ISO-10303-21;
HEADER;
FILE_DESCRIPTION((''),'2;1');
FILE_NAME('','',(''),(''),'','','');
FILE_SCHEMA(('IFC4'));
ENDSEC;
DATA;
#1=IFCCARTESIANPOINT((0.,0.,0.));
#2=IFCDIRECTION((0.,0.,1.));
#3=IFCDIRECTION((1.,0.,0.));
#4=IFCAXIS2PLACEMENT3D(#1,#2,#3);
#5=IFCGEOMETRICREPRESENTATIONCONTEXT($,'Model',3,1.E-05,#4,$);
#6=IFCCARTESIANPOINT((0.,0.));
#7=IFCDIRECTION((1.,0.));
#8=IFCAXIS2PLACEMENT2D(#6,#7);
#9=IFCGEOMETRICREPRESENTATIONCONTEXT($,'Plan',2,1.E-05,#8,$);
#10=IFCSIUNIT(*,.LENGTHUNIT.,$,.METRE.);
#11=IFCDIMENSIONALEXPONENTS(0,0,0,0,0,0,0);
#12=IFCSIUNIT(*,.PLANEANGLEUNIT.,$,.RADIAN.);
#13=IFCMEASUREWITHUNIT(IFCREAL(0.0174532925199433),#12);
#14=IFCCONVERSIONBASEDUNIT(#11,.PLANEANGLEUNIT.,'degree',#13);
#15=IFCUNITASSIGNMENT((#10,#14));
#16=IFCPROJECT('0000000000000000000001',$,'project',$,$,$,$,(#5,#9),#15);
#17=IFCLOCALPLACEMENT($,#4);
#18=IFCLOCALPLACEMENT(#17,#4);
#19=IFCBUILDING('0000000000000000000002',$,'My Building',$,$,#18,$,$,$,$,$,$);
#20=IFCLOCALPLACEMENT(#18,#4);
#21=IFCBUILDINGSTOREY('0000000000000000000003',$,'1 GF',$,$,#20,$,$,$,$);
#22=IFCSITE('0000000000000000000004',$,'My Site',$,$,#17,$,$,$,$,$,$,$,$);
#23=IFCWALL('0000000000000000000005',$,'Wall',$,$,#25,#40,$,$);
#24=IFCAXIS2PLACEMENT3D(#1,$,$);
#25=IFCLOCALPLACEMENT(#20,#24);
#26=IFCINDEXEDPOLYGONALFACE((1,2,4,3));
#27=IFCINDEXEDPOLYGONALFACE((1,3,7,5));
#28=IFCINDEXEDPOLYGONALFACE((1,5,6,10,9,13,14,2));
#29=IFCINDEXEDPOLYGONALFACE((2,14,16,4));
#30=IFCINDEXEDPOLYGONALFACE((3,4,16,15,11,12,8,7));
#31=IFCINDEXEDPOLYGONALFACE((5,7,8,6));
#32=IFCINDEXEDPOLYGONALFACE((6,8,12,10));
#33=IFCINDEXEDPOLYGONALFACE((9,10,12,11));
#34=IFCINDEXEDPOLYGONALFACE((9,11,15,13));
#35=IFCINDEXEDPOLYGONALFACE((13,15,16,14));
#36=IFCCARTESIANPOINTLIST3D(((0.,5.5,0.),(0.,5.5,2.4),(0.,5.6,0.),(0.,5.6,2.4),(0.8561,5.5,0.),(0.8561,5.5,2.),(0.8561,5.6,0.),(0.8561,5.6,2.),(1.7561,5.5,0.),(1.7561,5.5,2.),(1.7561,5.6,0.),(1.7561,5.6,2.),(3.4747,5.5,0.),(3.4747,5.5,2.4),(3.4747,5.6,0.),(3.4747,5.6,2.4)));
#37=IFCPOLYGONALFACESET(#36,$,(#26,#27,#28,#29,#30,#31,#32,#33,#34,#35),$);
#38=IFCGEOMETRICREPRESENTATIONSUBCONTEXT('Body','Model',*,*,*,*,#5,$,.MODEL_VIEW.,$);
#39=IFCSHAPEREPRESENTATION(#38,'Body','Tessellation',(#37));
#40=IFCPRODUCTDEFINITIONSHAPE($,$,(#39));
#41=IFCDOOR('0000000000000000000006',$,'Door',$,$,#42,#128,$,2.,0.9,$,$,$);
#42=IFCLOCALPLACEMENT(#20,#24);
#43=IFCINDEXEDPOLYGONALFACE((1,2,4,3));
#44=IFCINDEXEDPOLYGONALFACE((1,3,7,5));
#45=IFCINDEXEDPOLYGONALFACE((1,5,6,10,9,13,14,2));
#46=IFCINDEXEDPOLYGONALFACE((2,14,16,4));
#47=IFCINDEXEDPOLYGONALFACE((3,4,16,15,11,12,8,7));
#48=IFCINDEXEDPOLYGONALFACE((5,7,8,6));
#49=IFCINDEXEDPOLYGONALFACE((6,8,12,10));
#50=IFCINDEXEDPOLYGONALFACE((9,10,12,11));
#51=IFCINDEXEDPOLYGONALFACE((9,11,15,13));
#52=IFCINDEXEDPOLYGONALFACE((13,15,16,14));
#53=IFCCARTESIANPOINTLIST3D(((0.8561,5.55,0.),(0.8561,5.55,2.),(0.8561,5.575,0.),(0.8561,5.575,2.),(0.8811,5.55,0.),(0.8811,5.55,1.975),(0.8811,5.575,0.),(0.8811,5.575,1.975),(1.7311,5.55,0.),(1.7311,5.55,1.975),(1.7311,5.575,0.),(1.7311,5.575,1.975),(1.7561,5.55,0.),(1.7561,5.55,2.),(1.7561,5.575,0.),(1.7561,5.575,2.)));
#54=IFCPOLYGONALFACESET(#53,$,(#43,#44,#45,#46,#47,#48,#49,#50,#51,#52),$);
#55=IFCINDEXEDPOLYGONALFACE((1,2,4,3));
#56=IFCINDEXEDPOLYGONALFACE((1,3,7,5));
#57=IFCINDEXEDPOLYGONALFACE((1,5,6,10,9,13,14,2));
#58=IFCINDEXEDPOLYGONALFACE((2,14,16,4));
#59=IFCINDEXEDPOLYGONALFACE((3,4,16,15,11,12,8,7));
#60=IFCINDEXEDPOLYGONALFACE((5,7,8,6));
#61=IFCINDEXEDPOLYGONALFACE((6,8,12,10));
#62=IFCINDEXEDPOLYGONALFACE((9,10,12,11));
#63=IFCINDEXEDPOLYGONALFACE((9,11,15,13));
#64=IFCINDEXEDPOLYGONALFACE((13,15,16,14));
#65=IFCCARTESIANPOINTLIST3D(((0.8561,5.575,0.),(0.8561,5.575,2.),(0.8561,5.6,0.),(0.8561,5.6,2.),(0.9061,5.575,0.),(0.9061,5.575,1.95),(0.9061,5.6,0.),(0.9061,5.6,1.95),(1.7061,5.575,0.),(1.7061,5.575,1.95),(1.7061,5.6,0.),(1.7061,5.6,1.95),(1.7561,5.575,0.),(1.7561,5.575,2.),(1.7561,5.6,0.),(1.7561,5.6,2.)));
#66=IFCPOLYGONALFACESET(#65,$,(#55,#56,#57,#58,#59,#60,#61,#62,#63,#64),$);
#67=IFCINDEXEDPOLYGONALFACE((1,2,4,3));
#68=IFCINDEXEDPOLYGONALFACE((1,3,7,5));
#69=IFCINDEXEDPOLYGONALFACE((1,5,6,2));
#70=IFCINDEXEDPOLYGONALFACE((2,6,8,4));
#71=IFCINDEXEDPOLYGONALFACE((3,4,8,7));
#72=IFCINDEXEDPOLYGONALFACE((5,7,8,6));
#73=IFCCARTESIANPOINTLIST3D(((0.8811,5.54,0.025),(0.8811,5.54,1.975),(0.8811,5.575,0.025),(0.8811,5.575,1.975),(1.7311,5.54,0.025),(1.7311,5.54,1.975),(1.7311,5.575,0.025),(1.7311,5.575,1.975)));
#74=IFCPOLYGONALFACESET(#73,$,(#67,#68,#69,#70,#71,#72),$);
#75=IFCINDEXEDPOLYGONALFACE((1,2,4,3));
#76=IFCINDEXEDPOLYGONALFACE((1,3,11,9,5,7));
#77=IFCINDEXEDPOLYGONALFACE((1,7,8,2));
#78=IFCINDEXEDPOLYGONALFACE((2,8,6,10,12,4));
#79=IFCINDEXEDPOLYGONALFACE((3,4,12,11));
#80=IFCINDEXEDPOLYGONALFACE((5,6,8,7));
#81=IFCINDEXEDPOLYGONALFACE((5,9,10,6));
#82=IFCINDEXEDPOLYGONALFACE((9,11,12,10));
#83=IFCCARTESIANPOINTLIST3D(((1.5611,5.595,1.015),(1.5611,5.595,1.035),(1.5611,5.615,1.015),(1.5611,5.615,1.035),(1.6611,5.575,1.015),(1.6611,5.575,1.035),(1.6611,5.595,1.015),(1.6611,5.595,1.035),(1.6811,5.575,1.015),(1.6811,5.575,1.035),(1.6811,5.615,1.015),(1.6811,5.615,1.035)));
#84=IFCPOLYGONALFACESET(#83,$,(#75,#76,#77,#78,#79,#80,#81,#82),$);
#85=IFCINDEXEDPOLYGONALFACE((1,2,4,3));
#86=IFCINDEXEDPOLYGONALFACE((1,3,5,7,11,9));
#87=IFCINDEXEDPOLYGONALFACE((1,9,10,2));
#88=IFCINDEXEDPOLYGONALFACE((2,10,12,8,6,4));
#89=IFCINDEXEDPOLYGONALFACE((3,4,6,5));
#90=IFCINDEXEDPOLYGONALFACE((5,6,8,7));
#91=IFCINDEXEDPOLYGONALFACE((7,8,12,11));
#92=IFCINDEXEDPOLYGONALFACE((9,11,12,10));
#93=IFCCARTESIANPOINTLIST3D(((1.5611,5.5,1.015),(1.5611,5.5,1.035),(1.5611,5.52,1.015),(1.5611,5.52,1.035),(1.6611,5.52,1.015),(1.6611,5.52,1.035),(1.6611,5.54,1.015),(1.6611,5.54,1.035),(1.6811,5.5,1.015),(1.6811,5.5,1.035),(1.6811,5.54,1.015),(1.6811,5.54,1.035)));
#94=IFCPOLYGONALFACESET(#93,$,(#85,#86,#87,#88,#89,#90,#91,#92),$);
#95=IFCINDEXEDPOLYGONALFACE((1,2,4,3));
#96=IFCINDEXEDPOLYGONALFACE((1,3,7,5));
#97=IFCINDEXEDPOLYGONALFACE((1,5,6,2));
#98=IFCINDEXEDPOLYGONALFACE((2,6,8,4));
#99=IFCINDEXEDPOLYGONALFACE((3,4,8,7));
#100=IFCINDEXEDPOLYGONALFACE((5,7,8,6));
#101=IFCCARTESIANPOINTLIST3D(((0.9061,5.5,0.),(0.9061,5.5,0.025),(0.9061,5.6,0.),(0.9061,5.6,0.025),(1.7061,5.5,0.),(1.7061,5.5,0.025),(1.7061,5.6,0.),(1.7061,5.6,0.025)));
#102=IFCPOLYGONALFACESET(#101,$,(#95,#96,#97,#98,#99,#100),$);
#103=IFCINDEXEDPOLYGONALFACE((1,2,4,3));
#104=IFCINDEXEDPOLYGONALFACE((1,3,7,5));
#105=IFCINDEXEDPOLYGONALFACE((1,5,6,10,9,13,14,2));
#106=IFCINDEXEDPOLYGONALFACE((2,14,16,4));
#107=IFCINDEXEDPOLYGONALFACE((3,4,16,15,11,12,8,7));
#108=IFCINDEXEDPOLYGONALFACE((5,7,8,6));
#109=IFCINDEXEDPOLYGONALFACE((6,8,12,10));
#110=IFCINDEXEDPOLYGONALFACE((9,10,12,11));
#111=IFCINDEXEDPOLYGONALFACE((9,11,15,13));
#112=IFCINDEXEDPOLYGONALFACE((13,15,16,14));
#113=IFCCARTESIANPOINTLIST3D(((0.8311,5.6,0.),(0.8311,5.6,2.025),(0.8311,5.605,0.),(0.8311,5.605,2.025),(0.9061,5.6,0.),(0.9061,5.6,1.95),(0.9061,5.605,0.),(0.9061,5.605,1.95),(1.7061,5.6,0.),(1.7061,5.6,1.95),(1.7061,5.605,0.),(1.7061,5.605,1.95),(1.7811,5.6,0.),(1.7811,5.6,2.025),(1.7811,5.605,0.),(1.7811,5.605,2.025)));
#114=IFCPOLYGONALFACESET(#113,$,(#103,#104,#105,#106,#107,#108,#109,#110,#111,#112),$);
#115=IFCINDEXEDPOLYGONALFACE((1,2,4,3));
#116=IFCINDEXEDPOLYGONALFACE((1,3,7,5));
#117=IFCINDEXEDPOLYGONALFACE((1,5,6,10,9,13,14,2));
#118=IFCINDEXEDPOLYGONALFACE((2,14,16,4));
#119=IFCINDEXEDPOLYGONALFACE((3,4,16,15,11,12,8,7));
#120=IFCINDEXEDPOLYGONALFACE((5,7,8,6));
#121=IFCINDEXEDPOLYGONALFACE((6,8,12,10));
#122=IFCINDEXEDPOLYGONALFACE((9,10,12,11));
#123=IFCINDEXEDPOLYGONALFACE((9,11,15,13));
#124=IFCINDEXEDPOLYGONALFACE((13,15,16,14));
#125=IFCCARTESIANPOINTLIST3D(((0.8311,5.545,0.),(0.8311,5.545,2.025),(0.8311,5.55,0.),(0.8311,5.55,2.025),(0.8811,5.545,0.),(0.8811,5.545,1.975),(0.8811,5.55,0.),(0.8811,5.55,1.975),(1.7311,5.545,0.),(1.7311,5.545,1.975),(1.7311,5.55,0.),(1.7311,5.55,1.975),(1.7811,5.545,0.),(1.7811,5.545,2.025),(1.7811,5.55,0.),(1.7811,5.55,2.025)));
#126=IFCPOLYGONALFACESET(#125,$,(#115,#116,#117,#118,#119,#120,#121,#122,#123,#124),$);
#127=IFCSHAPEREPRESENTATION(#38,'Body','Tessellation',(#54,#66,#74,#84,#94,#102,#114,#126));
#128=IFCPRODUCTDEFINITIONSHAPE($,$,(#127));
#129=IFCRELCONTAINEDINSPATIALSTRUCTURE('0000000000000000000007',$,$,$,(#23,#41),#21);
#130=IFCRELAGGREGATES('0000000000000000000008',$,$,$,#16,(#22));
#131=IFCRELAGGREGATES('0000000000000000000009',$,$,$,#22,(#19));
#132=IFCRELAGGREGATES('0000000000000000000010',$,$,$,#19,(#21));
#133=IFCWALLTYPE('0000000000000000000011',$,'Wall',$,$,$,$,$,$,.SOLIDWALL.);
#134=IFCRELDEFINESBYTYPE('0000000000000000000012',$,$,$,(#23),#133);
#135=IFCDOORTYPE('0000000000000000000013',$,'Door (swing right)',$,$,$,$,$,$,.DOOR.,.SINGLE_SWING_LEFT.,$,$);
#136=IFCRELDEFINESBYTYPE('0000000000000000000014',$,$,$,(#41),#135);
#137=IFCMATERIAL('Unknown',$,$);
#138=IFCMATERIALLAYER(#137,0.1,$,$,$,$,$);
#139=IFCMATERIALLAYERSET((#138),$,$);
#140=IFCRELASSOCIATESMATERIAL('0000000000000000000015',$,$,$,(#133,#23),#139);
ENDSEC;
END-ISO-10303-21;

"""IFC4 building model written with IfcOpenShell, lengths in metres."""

from ifc_helpers import new_model, entity, si_unit, converted_unit, frame, origin_with_axes, origin_2d_with_axis, place, context, subcontext, project, spatial, line, indexed_curve, outline, extrude, shape, source, transform, mapped, material, layer, layer_set, layer_usage, type_object, type_shapes, element, fill, save


model = new_model("IFC4")

# Units and contexts
model_context = context("Model", 3, precision=1e-05, world=origin_with_axes())
plan_context = context("Plan", 2, precision=1e-05, world=origin_2d_with_axis())
body_context_1 = subcontext(model_context, "Body", "Model", "MODEL_VIEW")
body_context_2 = subcontext(plan_context, "Body", "Plan", "PLAN_VIEW")
ifc_project = project(units=[si_unit("LENGTHUNIT", "METRE"), converted_unit("PLANEANGLEUNIT", "degree", entity("IfcReal", 0.0174532925199433), si_unit("PLANEANGLEUNIT", "RADIAN"), dimensions=[0, 0, 0, 0, 0, 0, 0])], contexts=[model_context, plan_context])

# Site, building, storey
site_placement = place(None, origin_with_axes())
site = spatial("IfcSite", under=ifc_project, at=site_placement, Name="My Site")
building_placement = place(site_placement, origin_with_axes())
building = spatial("IfcBuilding", under=site, at=building_placement, Name="My Building")
storey_placement = place(building_placement, origin_with_axes())
storey = spatial("IfcBuildingStorey", under=building, at=storey_placement, Name="1 GF")

# Shared definitions
ifc_material = material(Name="Unknown")

# Shared definitions
ifc_layer_1 = layer(ifc_material, 0.1)
ifc_layer_set_1 = layer_set([ifc_layer_1])
wall_type = type_object("IfcWallType", Name="Wall", PredefinedType="SOLIDWALL", material=ifc_layer_set_1)
shared_shape_1 = source(origin_with_axes(), body_context_1, "Body", "SweptSolid", [
    extrude(outline(indexed_curve([(0.0, 0.0), (0.9, 0.0), (0.9, 2.0), (0.0, 2.0)], segments=[line(1, 2, 3, 4, 1)])), frame((0.0, -0.6, 0.0), z_axis=(0.0, -1.0, 0.0), x_axis=(1.0, 0.0, 0.0)), (0.0, 0.0, -1.0), 1.2),
])
door_type_1 = type_object("IfcDoorType", Name="Door (swing right)", OperationType="SINGLE_SWING_LEFT", PredefinedType="DOOR")
shared_shape_2 = source(origin_with_axes(), body_context_1, "Body", "SweptSolid", [
    extrude(outline(indexed_curve([(0.0, 0.0), (0.0, 2.0), (0.9, 2.0), (0.9, 0.0), (0.875, 0.0), (0.875, 1.975), (0.025, 1.975), (0.025, 0.0)], segments=[line(1, 2, 3, 4, 5, 6, 7, 8, 1)])), frame((0.0, 0.025, 0.0), z_axis=(0.0, -1.0, 0.0), x_axis=(1.0, 0.0, 0.0)), (0.0, 0.0, -1.0), 0.025),
    extrude(outline(indexed_curve([(0.0, 0.0), (0.0, 2.0), (0.9, 2.0), (0.9, 0.0), (0.85, 0.0), (0.85, 1.95), (0.05, 1.95), (0.05, 0.0)], segments=[line(1, 2, 3, 4, 5, 6, 7, 8, 1)])), frame((0.0, 0.0, 0.0), z_axis=(0.0, -1.0, 0.0), x_axis=(1.0, 0.0, 0.0)), (0.0, 0.0, -1.0), 0.025),
    extrude(outline(indexed_curve([(0.0, 0.0), (0.85, 0.0), (0.85, 0.035), (0.0, 0.035)], segments=[line(1, 2, 3, 4, 1)])), frame((0.025, 0.025, 0.025), z_axis=(0.0, 0.0, 1.0), x_axis=(1.0, 0.0, 0.0)), (0.0, 0.0, 1.0), 1.95),
    extrude(outline(indexed_curve([(0.0, 0.0), (0.0, -0.04), (0.12, -0.04), (0.12, -0.02), (0.02, -0.02), (0.02, 0.0)], segments=[line(1, 2, 3, 4, 5, 6, 1)])), frame((0.075, 0.025, 1.015), z_axis=(0.0, 0.0, 1.0), x_axis=(1.0, 0.0, 0.0)), (0.0, 0.0, 1.0), 0.02),
    extrude(outline(indexed_curve([(0.0, 0.0), (0.0, 0.04), (0.12, 0.04), (0.12, 0.02), (0.02, 0.02), (0.02, 0.0)], segments=[line(1, 2, 3, 4, 5, 6, 1)])), frame((0.075, 0.06, 1.015), z_axis=(0.0, 0.0, 1.0), x_axis=(1.0, 0.0, 0.0)), (0.0, 0.0, 1.0), 0.02),
    extrude(outline(indexed_curve([(0.0, 0.0), (0.8, 0.0), (0.8, 0.1), (0.0, 0.1)], segments=[line(1, 2, 3, 4, 1)])), frame((0.05, 0.0, 0.0), z_axis=(0.0, 0.0, 1.0), x_axis=(1.0, 0.0, 0.0)), (0.0, 0.0, 1.0), 0.025),
    extrude(outline(indexed_curve([(0.0, 0.0), (0.0, 2.025), (0.95, 2.025), (0.95, 0.0), (0.875, 0.0), (0.875, 1.95), (0.075, 1.95), (0.075, 0.0)], segments=[line(1, 2, 3, 4, 5, 6, 7, 8, 1)])), frame((-0.025, -0.005, 0.0), z_axis=(0.0, -1.0, 0.0), x_axis=(1.0, 0.0, 0.0)), (0.0, 0.0, -1.0), 0.005),
    extrude(outline(indexed_curve([(0.0, 0.0), (0.0, 2.025), (0.95, 2.025), (0.95, 0.0), (0.9, 0.0), (0.9, 1.975), (0.05, 1.975), (0.05, 0.0)], segments=[line(1, 2, 3, 4, 5, 6, 7, 8, 1)])), frame((-0.025, 0.05, 0.0), z_axis=(0.0, -1.0, 0.0), x_axis=(1.0, 0.0, 0.0)), (0.0, 0.0, -1.0), 0.005),
])
shared_shape_3 = source(origin_with_axes(), body_context_2, "Body", "Curve2D", [
    entity("IfcIndexedPolyCurve", entity("IfcCartesianPointList2D", [[0.0, 0.0], [0.0, 0.05], [0.025, 0.05], [0.025, 0.025], [0.05, 0.025], [0.05, 0.0]]), [entity("IfcLineIndex", [1, 2, 3, 4, 5, 6, 1])]),
    entity("IfcIndexedPolyCurve", entity("IfcCartesianPointList2D", [[0.9, 0.0], [0.9, 0.05], [0.875, 0.05], [0.875, 0.025], [0.85, 0.025], [0.85, 0.0]]), [entity("IfcLineIndex", [1, 2, 3, 4, 5, 6, 1])]),
    entity("IfcTrimmedCurve", entity("IfcEllipse", entity("IfcAxis2Placement2D", entity("IfcCartesianPoint", [0.84, 0.05]), entity("IfcDirection", [1.0, 0.0])), 0.815, 0.85), [entity("IfcCartesianPoint", [0.84, 0.9])], [entity("IfcCartesianPoint", [0.025, 0.05])], True, "CARTESIAN"),
    entity("IfcIndexedPolyCurve", entity("IfcCartesianPointList2D", [[0.875, 0.05], [0.84, 0.05], [0.84, 0.9], [0.875, 0.9]]), [entity("IfcLineIndex", [1, 2, 3, 4, 1])]),
])
type_shapes(door_type_1, [shared_shape_2, shared_shape_3])

# Wall, opening, door
ifc_layer_usage_1 = layer_usage(ifc_layer_set_1, "AXIS2", "POSITIVE", 0.0)
wall_1_placement = place(storey_placement, frame((3.4747, 5.6, 0.0), z_axis=(0.0, 0.0, 1.0), x_axis=(-1.0, 0.0, 0.0)))
wall_1 = element("IfcWall", 1, at=wall_1_placement, inside=storey, type_object=wall_type, material=ifc_layer_usage_1, Name="Wall", context=body_context_1, shape_type="SweptSolid", body=[
    extrude(outline(indexed_curve([(0.0, 0.0), (0.0, 0.1), (3.4747, 0.1), (3.4747, 0.0)], segments=[line(1, 2, 3, 4, 1)])), origin_with_axes(), (0.0, 0.0, 1.0), 2.4),
])
opening_1_placement = place(wall_1_placement, frame((1.7185, 0.0, 0.0), z_axis=(0.0, 0.0, 1.0), x_axis=(1.0, 0.0, 0.0)))
opening_1 = element("IfcOpeningElement", 2, at=opening_1_placement, cuts=wall_1, PredefinedType="OPENING", context=body_context_1, shape_type="MappedRepresentation", body=[
    mapped(shared_shape_1, transform((0.0, 0.0, 0.0), x_axis=(1.0, 0.0, 0.0), y_axis=(0.0, 1.0, 0.0), z_axis=(0.0, 0.0, 1.0), scale=1.0)),
])
door_1_placement = place(opening_1_placement, frame((0.0, 0.0, 0.0), z_axis=(0.0, 0.0, 1.0), x_axis=(1.0, 0.0, 0.0)))
door_1 = element("IfcDoor", 3, at=door_1_placement, inside=storey, type_object=door_type_1, Name="Door", OverallHeight=2.0, OverallWidth=0.9, shapes=[
    shape(body_context_1, "Body", "MappedRepresentation", [mapped(shared_shape_2, transform((0.0, 0.0, 0.0), x_axis=(1.0, 0.0, 0.0), y_axis=(0.0, 1.0, 0.0), z_axis=(0.0, 0.0, 1.0), scale=1.0))]),
    shape(body_context_2, "Body", "MappedRepresentation", [mapped(shared_shape_3, transform((0.0, 0.0, 0.0), x_axis=(1.0, 0.0, 0.0), y_axis=(0.0, 1.0, 0.0), z_axis=(0.0, 0.0, 1.0), scale=1.0))]),
])
fill(opening_1, door_1)

save(model, "model.ifc")
